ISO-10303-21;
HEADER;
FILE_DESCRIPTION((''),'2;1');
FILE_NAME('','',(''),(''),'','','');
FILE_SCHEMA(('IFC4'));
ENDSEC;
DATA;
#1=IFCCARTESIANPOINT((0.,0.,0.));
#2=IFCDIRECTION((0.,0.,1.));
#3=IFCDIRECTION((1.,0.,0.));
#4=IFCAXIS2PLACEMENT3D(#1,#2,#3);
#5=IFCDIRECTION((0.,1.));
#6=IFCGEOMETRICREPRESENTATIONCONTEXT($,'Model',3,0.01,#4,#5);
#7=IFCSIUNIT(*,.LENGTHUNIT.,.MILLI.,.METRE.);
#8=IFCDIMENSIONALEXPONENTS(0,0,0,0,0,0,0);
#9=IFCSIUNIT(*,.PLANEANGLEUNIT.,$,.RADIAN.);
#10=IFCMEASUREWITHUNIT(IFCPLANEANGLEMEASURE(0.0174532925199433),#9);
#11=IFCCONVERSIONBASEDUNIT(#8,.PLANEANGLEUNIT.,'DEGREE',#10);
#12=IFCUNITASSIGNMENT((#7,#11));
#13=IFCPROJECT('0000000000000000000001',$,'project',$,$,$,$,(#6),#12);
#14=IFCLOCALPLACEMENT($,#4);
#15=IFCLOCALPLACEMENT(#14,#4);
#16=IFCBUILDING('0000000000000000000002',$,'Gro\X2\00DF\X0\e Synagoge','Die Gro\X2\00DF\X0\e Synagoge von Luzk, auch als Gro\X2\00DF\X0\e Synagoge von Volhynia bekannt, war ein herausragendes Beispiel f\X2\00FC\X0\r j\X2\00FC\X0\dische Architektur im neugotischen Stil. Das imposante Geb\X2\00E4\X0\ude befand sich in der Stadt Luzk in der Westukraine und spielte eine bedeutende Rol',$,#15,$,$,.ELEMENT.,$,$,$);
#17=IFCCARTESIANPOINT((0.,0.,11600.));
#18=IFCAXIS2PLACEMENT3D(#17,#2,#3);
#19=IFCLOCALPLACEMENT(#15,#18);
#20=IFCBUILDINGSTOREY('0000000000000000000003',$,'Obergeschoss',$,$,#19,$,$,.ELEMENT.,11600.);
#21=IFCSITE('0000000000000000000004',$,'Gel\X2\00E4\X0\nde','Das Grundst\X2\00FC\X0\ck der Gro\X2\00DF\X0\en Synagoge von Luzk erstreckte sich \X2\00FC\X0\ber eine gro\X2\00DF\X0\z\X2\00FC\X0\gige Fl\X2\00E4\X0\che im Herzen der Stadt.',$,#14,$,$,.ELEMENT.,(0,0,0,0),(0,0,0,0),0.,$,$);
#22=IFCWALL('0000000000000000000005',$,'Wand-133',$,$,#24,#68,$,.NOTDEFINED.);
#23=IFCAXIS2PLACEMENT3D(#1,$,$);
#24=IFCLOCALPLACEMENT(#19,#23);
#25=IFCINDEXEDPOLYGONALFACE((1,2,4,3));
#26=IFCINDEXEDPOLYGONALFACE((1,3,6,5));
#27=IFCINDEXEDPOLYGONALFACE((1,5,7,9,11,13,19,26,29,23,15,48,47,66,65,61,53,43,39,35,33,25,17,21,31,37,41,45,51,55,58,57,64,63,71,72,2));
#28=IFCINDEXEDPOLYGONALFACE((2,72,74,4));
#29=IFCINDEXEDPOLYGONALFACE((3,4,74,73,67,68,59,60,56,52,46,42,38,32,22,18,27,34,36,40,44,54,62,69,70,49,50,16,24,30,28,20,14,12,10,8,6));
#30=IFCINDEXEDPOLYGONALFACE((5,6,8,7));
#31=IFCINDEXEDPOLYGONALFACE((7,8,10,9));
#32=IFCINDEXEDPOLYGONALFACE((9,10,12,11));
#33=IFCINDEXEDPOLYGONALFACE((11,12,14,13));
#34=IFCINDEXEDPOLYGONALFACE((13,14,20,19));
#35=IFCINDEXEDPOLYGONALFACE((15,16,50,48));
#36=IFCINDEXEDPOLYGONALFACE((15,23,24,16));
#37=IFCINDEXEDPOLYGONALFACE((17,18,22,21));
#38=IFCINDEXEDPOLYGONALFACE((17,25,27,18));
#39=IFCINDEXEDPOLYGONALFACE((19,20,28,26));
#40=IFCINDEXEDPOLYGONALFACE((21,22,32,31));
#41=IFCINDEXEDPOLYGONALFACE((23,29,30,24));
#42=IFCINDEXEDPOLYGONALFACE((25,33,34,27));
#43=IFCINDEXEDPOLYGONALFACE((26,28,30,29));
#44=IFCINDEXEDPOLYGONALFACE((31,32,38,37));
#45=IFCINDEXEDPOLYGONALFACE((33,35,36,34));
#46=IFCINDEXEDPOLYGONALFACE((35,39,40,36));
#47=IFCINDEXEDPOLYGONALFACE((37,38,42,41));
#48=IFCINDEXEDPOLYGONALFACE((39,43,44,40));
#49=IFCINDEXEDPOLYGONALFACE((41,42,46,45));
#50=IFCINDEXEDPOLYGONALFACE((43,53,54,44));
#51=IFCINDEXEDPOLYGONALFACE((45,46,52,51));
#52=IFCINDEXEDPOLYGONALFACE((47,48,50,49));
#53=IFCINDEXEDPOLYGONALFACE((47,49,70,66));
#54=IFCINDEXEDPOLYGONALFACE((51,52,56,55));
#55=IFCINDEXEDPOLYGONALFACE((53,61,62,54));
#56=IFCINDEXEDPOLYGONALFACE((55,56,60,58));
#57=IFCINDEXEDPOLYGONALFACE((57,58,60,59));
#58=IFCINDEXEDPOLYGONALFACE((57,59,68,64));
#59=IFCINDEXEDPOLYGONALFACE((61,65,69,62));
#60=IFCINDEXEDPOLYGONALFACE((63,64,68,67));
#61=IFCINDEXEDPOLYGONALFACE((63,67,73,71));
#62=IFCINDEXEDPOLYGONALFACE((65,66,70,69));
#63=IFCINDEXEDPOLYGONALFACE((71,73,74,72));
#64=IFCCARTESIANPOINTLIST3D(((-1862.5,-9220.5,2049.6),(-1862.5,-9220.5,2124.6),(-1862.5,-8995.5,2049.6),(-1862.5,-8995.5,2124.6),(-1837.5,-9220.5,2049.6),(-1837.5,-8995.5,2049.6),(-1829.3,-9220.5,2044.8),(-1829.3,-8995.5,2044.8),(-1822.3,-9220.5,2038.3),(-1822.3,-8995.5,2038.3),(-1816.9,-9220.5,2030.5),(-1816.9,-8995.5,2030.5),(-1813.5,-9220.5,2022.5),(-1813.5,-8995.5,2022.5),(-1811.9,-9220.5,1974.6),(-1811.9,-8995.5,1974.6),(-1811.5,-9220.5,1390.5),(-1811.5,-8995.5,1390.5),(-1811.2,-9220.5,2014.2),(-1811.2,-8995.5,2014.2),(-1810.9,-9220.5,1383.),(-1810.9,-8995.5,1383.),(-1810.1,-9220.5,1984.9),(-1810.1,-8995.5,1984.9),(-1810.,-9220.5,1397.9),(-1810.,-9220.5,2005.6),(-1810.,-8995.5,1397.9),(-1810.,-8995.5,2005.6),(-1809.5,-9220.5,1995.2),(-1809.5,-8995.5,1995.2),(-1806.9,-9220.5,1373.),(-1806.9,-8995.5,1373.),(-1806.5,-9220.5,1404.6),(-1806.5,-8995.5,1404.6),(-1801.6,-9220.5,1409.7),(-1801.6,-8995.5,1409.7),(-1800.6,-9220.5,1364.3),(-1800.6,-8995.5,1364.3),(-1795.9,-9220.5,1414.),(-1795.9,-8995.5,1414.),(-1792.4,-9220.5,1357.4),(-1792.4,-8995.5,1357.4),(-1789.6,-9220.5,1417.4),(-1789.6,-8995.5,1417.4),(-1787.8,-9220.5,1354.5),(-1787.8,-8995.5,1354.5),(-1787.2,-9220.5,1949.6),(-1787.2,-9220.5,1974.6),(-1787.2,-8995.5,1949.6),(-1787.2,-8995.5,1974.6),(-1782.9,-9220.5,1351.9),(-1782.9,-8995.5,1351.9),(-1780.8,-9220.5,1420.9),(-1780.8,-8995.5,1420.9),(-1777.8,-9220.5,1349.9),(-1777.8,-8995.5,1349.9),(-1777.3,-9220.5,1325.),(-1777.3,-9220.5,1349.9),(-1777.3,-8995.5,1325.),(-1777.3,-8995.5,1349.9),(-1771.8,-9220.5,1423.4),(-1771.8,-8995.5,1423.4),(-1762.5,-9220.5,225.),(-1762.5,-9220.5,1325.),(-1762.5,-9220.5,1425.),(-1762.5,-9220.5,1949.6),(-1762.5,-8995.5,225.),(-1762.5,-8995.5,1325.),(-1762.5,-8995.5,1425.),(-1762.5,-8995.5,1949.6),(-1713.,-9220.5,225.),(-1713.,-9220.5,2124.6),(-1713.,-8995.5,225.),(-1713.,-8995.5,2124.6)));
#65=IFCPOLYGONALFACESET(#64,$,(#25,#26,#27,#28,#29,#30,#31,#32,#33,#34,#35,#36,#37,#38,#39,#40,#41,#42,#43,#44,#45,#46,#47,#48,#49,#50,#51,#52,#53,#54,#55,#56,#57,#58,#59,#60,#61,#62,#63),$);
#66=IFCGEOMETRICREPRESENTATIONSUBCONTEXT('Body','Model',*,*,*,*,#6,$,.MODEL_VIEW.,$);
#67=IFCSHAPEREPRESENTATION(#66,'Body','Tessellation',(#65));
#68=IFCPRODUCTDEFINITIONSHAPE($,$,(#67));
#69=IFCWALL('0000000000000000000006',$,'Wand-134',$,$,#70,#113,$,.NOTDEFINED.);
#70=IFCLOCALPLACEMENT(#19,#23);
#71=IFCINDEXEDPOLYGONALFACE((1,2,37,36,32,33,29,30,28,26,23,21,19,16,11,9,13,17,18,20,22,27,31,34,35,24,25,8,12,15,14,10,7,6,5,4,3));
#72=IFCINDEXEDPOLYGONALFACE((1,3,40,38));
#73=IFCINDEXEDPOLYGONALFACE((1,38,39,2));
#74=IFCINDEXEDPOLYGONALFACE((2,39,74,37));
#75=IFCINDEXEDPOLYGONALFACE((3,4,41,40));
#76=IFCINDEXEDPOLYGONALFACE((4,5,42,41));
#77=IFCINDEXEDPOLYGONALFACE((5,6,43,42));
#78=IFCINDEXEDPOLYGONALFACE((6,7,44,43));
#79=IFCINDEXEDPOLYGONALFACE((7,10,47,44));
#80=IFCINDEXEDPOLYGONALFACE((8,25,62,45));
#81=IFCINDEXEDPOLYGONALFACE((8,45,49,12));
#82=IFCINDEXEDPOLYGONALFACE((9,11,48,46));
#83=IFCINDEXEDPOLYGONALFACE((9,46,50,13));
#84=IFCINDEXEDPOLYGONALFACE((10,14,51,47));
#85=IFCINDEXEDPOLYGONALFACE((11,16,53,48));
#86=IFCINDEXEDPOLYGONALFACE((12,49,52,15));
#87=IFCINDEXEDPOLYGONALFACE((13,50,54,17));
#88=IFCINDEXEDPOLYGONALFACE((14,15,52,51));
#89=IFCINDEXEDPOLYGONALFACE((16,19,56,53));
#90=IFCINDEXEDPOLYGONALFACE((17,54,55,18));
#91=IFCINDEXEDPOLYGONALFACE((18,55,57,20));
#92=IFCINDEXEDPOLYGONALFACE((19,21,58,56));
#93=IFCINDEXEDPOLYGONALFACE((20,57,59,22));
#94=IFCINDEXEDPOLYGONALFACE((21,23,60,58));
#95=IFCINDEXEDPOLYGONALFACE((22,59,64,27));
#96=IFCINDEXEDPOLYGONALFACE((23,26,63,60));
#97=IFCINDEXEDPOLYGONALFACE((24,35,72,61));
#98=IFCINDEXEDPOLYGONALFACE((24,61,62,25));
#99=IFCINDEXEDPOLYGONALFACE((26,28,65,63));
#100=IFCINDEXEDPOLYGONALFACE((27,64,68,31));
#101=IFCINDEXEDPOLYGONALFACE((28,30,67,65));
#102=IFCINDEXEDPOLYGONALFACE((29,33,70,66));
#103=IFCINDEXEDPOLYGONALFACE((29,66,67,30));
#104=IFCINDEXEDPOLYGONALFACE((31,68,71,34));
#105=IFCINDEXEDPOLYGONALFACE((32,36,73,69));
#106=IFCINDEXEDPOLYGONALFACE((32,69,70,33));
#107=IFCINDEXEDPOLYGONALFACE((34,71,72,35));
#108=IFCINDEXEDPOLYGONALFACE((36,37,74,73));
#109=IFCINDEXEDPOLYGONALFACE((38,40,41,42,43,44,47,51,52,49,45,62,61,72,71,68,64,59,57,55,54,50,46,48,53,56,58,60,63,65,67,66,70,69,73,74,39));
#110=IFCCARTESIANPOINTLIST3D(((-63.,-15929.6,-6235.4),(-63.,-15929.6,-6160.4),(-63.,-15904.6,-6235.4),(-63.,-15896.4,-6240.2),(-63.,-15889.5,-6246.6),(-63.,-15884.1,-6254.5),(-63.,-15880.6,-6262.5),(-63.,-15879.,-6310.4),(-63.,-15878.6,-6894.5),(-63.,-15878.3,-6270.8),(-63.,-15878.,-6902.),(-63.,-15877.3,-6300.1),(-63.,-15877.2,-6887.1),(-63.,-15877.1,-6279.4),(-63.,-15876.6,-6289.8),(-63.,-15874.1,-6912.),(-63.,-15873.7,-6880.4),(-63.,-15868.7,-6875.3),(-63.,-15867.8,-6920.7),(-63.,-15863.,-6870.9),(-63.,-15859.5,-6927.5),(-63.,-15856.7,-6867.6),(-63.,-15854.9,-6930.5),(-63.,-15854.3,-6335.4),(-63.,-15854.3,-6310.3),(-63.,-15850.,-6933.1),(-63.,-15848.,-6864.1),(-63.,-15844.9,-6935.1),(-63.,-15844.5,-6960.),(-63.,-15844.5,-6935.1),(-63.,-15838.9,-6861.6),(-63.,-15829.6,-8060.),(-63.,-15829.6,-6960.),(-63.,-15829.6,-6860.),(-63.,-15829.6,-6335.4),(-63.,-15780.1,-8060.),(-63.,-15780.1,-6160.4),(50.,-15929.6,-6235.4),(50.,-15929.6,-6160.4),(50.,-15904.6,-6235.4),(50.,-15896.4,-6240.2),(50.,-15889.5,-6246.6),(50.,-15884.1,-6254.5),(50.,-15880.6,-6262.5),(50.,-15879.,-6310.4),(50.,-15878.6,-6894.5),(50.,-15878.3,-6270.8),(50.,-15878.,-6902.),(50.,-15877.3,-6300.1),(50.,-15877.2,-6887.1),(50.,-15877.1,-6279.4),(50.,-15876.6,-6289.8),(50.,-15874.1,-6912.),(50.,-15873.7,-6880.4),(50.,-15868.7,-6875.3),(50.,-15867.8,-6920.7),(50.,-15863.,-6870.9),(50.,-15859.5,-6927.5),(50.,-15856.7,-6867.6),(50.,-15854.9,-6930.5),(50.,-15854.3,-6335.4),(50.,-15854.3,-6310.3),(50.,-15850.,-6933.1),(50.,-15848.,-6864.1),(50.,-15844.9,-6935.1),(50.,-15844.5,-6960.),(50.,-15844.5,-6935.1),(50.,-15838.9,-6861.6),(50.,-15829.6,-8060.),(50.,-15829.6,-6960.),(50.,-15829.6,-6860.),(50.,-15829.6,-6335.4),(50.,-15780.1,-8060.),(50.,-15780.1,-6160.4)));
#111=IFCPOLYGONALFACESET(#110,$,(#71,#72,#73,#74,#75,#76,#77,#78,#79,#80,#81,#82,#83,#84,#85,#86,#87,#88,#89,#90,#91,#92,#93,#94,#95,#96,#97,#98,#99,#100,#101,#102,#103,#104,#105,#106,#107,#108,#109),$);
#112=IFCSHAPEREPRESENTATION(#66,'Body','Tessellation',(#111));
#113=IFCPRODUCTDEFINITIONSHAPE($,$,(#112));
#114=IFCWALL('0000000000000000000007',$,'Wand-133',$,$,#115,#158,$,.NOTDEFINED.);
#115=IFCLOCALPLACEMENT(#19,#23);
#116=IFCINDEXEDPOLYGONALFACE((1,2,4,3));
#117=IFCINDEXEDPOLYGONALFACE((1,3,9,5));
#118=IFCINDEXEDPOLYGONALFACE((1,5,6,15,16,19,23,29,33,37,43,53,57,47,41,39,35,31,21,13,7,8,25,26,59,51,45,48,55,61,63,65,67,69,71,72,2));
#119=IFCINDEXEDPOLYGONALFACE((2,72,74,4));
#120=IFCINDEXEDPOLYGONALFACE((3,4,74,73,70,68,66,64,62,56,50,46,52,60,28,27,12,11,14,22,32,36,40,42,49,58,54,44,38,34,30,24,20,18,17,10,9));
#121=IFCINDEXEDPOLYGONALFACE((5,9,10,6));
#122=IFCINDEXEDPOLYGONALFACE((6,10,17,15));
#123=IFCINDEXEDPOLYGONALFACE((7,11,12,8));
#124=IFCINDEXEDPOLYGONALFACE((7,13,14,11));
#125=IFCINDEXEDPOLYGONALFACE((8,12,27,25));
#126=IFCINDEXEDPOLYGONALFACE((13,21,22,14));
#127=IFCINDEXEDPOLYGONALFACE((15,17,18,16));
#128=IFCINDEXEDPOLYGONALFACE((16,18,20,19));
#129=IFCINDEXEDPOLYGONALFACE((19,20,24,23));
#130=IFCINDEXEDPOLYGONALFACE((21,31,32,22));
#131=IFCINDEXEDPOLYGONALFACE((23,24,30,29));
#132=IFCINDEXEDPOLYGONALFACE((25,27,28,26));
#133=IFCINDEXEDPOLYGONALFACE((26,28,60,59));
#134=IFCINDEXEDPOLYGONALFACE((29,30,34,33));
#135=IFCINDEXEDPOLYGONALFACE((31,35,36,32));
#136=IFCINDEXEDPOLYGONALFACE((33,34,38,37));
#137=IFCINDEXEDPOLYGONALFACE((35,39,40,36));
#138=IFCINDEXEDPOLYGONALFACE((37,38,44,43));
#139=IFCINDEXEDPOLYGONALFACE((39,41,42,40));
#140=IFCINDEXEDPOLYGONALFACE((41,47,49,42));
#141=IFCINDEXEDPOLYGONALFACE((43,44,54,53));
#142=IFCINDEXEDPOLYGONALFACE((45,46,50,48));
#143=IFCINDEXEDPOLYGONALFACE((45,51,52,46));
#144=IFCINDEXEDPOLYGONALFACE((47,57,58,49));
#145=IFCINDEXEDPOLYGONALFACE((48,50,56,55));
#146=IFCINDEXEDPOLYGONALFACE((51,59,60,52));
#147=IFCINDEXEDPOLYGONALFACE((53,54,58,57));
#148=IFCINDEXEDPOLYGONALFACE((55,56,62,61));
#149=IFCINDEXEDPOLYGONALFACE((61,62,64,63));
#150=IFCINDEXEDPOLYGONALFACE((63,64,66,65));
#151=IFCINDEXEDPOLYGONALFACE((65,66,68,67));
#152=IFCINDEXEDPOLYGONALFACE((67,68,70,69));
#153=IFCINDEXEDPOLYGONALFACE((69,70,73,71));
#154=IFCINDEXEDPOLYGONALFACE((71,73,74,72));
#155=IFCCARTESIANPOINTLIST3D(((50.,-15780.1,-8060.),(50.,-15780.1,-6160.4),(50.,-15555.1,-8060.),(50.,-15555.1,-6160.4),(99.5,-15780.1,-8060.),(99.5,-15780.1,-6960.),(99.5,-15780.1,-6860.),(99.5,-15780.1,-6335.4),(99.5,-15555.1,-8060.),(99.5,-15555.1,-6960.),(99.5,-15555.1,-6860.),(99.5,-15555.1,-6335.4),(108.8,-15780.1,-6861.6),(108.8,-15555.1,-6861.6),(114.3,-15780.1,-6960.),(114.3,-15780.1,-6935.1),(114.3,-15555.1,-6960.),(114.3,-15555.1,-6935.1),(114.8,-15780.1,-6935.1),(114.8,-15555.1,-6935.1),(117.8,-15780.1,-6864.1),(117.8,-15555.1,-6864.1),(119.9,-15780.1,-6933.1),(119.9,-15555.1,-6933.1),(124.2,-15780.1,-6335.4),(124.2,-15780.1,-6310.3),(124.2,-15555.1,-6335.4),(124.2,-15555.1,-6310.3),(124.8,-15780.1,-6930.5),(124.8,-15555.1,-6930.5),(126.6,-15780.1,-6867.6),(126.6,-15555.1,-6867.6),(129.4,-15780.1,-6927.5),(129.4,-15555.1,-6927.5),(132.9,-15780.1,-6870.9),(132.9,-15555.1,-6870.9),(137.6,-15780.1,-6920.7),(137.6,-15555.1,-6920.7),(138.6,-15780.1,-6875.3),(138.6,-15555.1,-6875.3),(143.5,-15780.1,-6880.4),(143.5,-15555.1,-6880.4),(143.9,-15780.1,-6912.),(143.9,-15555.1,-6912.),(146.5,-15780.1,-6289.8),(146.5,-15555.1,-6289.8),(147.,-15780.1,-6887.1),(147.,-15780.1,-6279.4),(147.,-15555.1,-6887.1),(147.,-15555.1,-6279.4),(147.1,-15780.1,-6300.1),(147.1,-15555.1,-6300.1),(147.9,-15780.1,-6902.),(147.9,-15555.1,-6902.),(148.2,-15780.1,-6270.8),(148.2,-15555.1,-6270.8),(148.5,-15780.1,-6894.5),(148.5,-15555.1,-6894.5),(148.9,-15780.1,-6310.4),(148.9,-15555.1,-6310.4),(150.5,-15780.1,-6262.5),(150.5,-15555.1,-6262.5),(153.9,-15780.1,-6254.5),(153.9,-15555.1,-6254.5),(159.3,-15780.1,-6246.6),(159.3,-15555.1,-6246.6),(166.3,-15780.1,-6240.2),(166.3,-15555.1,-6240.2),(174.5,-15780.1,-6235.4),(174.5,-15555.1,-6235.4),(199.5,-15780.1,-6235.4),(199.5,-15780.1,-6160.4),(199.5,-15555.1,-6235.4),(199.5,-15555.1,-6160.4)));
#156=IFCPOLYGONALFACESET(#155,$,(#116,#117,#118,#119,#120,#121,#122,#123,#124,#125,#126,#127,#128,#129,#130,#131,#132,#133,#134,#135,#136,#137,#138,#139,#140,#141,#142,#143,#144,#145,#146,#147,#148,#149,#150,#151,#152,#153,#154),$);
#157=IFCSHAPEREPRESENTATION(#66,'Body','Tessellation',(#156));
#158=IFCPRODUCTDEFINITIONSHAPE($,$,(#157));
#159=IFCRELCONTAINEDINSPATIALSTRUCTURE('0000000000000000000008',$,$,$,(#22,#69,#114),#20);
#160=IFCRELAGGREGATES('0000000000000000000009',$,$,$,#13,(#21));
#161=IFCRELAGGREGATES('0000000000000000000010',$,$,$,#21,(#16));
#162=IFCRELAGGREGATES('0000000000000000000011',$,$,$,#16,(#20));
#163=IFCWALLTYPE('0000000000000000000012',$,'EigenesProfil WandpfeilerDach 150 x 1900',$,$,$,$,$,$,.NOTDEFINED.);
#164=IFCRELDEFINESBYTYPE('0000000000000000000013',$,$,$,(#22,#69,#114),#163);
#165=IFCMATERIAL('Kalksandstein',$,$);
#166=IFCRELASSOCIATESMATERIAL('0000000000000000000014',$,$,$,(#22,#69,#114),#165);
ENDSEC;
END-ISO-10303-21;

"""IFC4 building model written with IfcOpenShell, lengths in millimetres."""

from ifc_helpers import new_model, entity, si_unit, converted_unit, direction, frame, origin_with_axes, place, context, subcontext, project, spatial, line, arc, indexed_curve, outline, extrude, material, material_profile, profile_set, type_object, element, save


model = new_model("IFC4")

# Units and contexts
model_context = context("Model", 3, precision=0.01, world=origin_with_axes(), true_north=direction((0.0, 1.0)))
body_context = subcontext(model_context, "Body", "Model", "MODEL_VIEW")
ifc_project = project(units=[si_unit("LENGTHUNIT", "METRE", prefix="MILLI"), converted_unit("PLANEANGLEUNIT", "DEGREE", entity("IfcPlaneAngleMeasure", 0.0174532925199433), si_unit("PLANEANGLEUNIT", "RADIAN"), dimensions=[0, 0, 0, 0, 0, 0, 0])], contexts=[model_context])

# Site, building, storey
site_placement = place(None, origin_with_axes())
site = spatial("IfcSite", under=ifc_project, at=site_placement, Name="Gelände", Description="Das Grundstück der Großen Synagoge von Luzk erstreckte sich über eine großzügige Fläche im Herzen der Stadt.", CompositionType="ELEMENT", RefLatitude=(0, 0, 0, 0), RefLongitude=(0, 0, 0, 0), RefElevation=0.0)
building_placement = place(site_placement, origin_with_axes())
building = spatial("IfcBuilding", under=site, at=building_placement, Name="Große Synagoge", Description="Die Große Synagoge von Luzk, auch als Große Synagoge von Volhynia bekannt, war ein herausragendes Beispiel für jüdische Architektur im neugotischen Stil. Das imposante Gebäude befand sich in der Stadt Luzk in der Westukraine und spielte eine bedeutende Rol", CompositionType="ELEMENT")
storey_placement = place(building_placement, frame((0.0, 0.0, 11600.0), z_axis=(0.0, 0.0, 1.0), x_axis=(1.0, 0.0, 0.0)))
storey = spatial("IfcBuildingStorey", under=building, at=storey_placement, Name="Obergeschoss", CompositionType="ELEMENT", Elevation=11600.0)

# Walls
ifc_material_1 = material(Name="Kalksandstein")
ifc_material_profile = material_profile(ifc_material_1, outline(indexed_curve([(74.2, 1749.6), (98.9, 1749.6), (96.7, 1765.0), (97.0, 1780.5), (99.2, 1793.4), (103.9, 1805.5), (112.6, 1816.7), (124.5, 1824.6), (149.5, 1824.6), (149.5, 1899.6), (0.0, 1899.6), (0.0, 0.0), (49.5, 0.0), (49.5, 1100.0), (64.3, 1100.0), (64.3, 1124.9), (64.8, 1124.9), (72.4, 1128.1), (79.4, 1132.4), (91.1, 1143.4), (97.9, 1157.9), (98.0, 1169.2), (93.5, 1179.5), (85.8, 1187.0), (76.6, 1192.3), (63.3, 1197.2), (49.5, 1200.0), (49.5, 1724.6), (74.2, 1724.6)], segments=[line(1, 2), arc(2, 3, 4), arc(4, 5, 6), arc(6, 7, 8), line(8, 9, 10, 11, 12, 13, 14, 15, 16, 17), arc(17, 18, 19), arc(19, 20, 21), arc(21, 22, 23), arc(23, 24, 25), arc(25, 26, 27), line(27, 28, 29, 1)])), Name="Kalksandstein")
ifc_profile_set = profile_set([ifc_material_profile], Name="EigenesProfil WandpfeilerDach")
wall_type_1 = type_object("IfcWallType", Name="EigenesProfil WandpfeilerDach 150 x 1900", PredefinedType="NOTDEFINED")
wall_1_placement = place(storey_placement, frame((-1713.0, -8995.5, 225.0), z_axis=(0.0, 0.0, 1.0), x_axis=(0.0, -1.0, 0.0)))
element("IfcWall", 1, at=wall_1_placement, inside=storey, type_object=wall_type_1, material=ifc_profile_set, Name="Wand-133", PredefinedType="NOTDEFINED", context=body_context, shape_type="SweptSolid", body=[
    extrude(outline(indexed_curve([(74.2, 1749.6), (98.9, 1749.6), (96.7, 1765.0), (97.0, 1780.5), (99.2, 1793.4), (103.9, 1805.5), (112.6, 1816.7), (124.5, 1824.6), (149.5, 1824.6), (149.5, 1899.6), (0.0, 1899.6), (0.0, 0.0), (49.5, 0.0), (49.5, 1100.0), (64.3, 1100.0), (64.3, 1124.9), (64.8, 1124.9), (72.4, 1128.1), (79.4, 1132.4), (91.1, 1143.4), (97.9, 1157.9), (98.0, 1169.2), (93.5, 1179.5), (85.8, 1187.0), (76.6, 1192.3), (63.3, 1197.2), (49.5, 1200.0), (49.5, 1724.6), (74.2, 1724.6)], segments=[line(1, 2), arc(2, 3, 4), arc(4, 5, 6), arc(6, 7, 8), line(8, 9, 10, 11, 12, 13, 14, 15, 16, 17), arc(17, 18, 19), arc(19, 20, 21), arc(21, 22, 23), arc(23, 24, 25), arc(25, 26, 27), line(27, 28, 29, 1)])), frame((0.0, 0.0, 0.0), z_axis=(-1.0, 0.0, 0.0), x_axis=(0.0, -1.0, 0.0)), (0.0, 0.0, -1.0), 225.0),
])
wall_2_placement = place(storey_placement, frame((50.0, -15780.1, -8060.0), z_axis=(0.0, 0.0, 1.0), x_axis=(-1.0, 0.0, 0.0)))
element("IfcWall", 2, at=wall_2_placement, inside=storey, type_object=wall_type_1, material=ifc_profile_set, Name="Wand-134", PredefinedType="NOTDEFINED", context=body_context, shape_type="SweptSolid", body=[
    extrude(outline(indexed_curve([(74.2, 1749.6), (98.9, 1749.6), (96.7, 1765.0), (97.0, 1780.5), (99.2, 1793.4), (103.9, 1805.5), (112.6, 1816.7), (124.5, 1824.6), (149.5, 1824.6), (149.5, 1899.6), (0.0, 1899.6), (0.0, 0.0), (49.5, 0.0), (49.5, 1100.0), (64.3, 1100.0), (64.3, 1124.9), (64.8, 1124.9), (72.4, 1128.1), (79.4, 1132.4), (91.1, 1143.4), (97.9, 1157.9), (98.0, 1169.2), (93.5, 1179.5), (85.8, 1187.0), (76.6, 1192.3), (63.3, 1197.2), (49.5, 1200.0), (49.5, 1724.6), (74.2, 1724.6)], segments=[line(1, 2), arc(2, 3, 4), arc(4, 5, 6), arc(6, 7, 8), line(8, 9, 10, 11, 12, 13, 14, 15, 16, 17), arc(17, 18, 19), arc(19, 20, 21), arc(21, 22, 23), arc(23, 24, 25), arc(25, 26, 27), line(27, 28, 29, 1)])), frame((0.0, 0.0, 0.0), z_axis=(1.0, 0.0, 0.0), x_axis=(0.0, 1.0, 0.0)), (0.0, 0.0, 1.0), 113.0),
])
wall_3_placement = place(storey_placement, frame((50.0, -15555.1, -8060.0), z_axis=(0.0, 0.0, 1.0), x_axis=(0.0, -1.0, 0.0)))
element("IfcWall", 3, at=wall_3_placement, inside=storey, type_object=wall_type_1, material=ifc_profile_set, Name="Wand-133", PredefinedType="NOTDEFINED", context=body_context, shape_type="SweptSolid", body=[
    extrude(outline(indexed_curve([(74.2, 1749.6), (98.9, 1749.6), (96.7, 1765.0), (97.0, 1780.5), (99.2, 1793.4), (103.9, 1805.5), (112.6, 1816.7), (124.5, 1824.6), (149.5, 1824.6), (149.5, 1899.6), (0.0, 1899.6), (0.0, 0.0), (49.5, 0.0), (49.5, 1100.0), (64.3, 1100.0), (64.3, 1124.9), (64.8, 1124.9), (72.4, 1128.1), (79.4, 1132.4), (91.1, 1143.4), (97.9, 1157.9), (98.0, 1169.2), (93.5, 1179.5), (85.8, 1187.0), (76.6, 1192.3), (63.3, 1197.2), (49.5, 1200.0), (49.5, 1724.6), (74.2, 1724.6)], segments=[line(1, 2), arc(2, 3, 4), arc(4, 5, 6), arc(6, 7, 8), line(8, 9, 10, 11, 12, 13, 14, 15, 16, 17), arc(17, 18, 19), arc(19, 20, 21), arc(21, 22, 23), arc(23, 24, 25), arc(25, 26, 27), line(27, 28, 29, 1)])), frame((0.0, 0.0, 0.0), z_axis=(1.0, 0.0, 0.0), x_axis=(0.0, 1.0, 0.0)), (0.0, 0.0, 1.0), 225.0),
])

save(model, "model.ifc")
